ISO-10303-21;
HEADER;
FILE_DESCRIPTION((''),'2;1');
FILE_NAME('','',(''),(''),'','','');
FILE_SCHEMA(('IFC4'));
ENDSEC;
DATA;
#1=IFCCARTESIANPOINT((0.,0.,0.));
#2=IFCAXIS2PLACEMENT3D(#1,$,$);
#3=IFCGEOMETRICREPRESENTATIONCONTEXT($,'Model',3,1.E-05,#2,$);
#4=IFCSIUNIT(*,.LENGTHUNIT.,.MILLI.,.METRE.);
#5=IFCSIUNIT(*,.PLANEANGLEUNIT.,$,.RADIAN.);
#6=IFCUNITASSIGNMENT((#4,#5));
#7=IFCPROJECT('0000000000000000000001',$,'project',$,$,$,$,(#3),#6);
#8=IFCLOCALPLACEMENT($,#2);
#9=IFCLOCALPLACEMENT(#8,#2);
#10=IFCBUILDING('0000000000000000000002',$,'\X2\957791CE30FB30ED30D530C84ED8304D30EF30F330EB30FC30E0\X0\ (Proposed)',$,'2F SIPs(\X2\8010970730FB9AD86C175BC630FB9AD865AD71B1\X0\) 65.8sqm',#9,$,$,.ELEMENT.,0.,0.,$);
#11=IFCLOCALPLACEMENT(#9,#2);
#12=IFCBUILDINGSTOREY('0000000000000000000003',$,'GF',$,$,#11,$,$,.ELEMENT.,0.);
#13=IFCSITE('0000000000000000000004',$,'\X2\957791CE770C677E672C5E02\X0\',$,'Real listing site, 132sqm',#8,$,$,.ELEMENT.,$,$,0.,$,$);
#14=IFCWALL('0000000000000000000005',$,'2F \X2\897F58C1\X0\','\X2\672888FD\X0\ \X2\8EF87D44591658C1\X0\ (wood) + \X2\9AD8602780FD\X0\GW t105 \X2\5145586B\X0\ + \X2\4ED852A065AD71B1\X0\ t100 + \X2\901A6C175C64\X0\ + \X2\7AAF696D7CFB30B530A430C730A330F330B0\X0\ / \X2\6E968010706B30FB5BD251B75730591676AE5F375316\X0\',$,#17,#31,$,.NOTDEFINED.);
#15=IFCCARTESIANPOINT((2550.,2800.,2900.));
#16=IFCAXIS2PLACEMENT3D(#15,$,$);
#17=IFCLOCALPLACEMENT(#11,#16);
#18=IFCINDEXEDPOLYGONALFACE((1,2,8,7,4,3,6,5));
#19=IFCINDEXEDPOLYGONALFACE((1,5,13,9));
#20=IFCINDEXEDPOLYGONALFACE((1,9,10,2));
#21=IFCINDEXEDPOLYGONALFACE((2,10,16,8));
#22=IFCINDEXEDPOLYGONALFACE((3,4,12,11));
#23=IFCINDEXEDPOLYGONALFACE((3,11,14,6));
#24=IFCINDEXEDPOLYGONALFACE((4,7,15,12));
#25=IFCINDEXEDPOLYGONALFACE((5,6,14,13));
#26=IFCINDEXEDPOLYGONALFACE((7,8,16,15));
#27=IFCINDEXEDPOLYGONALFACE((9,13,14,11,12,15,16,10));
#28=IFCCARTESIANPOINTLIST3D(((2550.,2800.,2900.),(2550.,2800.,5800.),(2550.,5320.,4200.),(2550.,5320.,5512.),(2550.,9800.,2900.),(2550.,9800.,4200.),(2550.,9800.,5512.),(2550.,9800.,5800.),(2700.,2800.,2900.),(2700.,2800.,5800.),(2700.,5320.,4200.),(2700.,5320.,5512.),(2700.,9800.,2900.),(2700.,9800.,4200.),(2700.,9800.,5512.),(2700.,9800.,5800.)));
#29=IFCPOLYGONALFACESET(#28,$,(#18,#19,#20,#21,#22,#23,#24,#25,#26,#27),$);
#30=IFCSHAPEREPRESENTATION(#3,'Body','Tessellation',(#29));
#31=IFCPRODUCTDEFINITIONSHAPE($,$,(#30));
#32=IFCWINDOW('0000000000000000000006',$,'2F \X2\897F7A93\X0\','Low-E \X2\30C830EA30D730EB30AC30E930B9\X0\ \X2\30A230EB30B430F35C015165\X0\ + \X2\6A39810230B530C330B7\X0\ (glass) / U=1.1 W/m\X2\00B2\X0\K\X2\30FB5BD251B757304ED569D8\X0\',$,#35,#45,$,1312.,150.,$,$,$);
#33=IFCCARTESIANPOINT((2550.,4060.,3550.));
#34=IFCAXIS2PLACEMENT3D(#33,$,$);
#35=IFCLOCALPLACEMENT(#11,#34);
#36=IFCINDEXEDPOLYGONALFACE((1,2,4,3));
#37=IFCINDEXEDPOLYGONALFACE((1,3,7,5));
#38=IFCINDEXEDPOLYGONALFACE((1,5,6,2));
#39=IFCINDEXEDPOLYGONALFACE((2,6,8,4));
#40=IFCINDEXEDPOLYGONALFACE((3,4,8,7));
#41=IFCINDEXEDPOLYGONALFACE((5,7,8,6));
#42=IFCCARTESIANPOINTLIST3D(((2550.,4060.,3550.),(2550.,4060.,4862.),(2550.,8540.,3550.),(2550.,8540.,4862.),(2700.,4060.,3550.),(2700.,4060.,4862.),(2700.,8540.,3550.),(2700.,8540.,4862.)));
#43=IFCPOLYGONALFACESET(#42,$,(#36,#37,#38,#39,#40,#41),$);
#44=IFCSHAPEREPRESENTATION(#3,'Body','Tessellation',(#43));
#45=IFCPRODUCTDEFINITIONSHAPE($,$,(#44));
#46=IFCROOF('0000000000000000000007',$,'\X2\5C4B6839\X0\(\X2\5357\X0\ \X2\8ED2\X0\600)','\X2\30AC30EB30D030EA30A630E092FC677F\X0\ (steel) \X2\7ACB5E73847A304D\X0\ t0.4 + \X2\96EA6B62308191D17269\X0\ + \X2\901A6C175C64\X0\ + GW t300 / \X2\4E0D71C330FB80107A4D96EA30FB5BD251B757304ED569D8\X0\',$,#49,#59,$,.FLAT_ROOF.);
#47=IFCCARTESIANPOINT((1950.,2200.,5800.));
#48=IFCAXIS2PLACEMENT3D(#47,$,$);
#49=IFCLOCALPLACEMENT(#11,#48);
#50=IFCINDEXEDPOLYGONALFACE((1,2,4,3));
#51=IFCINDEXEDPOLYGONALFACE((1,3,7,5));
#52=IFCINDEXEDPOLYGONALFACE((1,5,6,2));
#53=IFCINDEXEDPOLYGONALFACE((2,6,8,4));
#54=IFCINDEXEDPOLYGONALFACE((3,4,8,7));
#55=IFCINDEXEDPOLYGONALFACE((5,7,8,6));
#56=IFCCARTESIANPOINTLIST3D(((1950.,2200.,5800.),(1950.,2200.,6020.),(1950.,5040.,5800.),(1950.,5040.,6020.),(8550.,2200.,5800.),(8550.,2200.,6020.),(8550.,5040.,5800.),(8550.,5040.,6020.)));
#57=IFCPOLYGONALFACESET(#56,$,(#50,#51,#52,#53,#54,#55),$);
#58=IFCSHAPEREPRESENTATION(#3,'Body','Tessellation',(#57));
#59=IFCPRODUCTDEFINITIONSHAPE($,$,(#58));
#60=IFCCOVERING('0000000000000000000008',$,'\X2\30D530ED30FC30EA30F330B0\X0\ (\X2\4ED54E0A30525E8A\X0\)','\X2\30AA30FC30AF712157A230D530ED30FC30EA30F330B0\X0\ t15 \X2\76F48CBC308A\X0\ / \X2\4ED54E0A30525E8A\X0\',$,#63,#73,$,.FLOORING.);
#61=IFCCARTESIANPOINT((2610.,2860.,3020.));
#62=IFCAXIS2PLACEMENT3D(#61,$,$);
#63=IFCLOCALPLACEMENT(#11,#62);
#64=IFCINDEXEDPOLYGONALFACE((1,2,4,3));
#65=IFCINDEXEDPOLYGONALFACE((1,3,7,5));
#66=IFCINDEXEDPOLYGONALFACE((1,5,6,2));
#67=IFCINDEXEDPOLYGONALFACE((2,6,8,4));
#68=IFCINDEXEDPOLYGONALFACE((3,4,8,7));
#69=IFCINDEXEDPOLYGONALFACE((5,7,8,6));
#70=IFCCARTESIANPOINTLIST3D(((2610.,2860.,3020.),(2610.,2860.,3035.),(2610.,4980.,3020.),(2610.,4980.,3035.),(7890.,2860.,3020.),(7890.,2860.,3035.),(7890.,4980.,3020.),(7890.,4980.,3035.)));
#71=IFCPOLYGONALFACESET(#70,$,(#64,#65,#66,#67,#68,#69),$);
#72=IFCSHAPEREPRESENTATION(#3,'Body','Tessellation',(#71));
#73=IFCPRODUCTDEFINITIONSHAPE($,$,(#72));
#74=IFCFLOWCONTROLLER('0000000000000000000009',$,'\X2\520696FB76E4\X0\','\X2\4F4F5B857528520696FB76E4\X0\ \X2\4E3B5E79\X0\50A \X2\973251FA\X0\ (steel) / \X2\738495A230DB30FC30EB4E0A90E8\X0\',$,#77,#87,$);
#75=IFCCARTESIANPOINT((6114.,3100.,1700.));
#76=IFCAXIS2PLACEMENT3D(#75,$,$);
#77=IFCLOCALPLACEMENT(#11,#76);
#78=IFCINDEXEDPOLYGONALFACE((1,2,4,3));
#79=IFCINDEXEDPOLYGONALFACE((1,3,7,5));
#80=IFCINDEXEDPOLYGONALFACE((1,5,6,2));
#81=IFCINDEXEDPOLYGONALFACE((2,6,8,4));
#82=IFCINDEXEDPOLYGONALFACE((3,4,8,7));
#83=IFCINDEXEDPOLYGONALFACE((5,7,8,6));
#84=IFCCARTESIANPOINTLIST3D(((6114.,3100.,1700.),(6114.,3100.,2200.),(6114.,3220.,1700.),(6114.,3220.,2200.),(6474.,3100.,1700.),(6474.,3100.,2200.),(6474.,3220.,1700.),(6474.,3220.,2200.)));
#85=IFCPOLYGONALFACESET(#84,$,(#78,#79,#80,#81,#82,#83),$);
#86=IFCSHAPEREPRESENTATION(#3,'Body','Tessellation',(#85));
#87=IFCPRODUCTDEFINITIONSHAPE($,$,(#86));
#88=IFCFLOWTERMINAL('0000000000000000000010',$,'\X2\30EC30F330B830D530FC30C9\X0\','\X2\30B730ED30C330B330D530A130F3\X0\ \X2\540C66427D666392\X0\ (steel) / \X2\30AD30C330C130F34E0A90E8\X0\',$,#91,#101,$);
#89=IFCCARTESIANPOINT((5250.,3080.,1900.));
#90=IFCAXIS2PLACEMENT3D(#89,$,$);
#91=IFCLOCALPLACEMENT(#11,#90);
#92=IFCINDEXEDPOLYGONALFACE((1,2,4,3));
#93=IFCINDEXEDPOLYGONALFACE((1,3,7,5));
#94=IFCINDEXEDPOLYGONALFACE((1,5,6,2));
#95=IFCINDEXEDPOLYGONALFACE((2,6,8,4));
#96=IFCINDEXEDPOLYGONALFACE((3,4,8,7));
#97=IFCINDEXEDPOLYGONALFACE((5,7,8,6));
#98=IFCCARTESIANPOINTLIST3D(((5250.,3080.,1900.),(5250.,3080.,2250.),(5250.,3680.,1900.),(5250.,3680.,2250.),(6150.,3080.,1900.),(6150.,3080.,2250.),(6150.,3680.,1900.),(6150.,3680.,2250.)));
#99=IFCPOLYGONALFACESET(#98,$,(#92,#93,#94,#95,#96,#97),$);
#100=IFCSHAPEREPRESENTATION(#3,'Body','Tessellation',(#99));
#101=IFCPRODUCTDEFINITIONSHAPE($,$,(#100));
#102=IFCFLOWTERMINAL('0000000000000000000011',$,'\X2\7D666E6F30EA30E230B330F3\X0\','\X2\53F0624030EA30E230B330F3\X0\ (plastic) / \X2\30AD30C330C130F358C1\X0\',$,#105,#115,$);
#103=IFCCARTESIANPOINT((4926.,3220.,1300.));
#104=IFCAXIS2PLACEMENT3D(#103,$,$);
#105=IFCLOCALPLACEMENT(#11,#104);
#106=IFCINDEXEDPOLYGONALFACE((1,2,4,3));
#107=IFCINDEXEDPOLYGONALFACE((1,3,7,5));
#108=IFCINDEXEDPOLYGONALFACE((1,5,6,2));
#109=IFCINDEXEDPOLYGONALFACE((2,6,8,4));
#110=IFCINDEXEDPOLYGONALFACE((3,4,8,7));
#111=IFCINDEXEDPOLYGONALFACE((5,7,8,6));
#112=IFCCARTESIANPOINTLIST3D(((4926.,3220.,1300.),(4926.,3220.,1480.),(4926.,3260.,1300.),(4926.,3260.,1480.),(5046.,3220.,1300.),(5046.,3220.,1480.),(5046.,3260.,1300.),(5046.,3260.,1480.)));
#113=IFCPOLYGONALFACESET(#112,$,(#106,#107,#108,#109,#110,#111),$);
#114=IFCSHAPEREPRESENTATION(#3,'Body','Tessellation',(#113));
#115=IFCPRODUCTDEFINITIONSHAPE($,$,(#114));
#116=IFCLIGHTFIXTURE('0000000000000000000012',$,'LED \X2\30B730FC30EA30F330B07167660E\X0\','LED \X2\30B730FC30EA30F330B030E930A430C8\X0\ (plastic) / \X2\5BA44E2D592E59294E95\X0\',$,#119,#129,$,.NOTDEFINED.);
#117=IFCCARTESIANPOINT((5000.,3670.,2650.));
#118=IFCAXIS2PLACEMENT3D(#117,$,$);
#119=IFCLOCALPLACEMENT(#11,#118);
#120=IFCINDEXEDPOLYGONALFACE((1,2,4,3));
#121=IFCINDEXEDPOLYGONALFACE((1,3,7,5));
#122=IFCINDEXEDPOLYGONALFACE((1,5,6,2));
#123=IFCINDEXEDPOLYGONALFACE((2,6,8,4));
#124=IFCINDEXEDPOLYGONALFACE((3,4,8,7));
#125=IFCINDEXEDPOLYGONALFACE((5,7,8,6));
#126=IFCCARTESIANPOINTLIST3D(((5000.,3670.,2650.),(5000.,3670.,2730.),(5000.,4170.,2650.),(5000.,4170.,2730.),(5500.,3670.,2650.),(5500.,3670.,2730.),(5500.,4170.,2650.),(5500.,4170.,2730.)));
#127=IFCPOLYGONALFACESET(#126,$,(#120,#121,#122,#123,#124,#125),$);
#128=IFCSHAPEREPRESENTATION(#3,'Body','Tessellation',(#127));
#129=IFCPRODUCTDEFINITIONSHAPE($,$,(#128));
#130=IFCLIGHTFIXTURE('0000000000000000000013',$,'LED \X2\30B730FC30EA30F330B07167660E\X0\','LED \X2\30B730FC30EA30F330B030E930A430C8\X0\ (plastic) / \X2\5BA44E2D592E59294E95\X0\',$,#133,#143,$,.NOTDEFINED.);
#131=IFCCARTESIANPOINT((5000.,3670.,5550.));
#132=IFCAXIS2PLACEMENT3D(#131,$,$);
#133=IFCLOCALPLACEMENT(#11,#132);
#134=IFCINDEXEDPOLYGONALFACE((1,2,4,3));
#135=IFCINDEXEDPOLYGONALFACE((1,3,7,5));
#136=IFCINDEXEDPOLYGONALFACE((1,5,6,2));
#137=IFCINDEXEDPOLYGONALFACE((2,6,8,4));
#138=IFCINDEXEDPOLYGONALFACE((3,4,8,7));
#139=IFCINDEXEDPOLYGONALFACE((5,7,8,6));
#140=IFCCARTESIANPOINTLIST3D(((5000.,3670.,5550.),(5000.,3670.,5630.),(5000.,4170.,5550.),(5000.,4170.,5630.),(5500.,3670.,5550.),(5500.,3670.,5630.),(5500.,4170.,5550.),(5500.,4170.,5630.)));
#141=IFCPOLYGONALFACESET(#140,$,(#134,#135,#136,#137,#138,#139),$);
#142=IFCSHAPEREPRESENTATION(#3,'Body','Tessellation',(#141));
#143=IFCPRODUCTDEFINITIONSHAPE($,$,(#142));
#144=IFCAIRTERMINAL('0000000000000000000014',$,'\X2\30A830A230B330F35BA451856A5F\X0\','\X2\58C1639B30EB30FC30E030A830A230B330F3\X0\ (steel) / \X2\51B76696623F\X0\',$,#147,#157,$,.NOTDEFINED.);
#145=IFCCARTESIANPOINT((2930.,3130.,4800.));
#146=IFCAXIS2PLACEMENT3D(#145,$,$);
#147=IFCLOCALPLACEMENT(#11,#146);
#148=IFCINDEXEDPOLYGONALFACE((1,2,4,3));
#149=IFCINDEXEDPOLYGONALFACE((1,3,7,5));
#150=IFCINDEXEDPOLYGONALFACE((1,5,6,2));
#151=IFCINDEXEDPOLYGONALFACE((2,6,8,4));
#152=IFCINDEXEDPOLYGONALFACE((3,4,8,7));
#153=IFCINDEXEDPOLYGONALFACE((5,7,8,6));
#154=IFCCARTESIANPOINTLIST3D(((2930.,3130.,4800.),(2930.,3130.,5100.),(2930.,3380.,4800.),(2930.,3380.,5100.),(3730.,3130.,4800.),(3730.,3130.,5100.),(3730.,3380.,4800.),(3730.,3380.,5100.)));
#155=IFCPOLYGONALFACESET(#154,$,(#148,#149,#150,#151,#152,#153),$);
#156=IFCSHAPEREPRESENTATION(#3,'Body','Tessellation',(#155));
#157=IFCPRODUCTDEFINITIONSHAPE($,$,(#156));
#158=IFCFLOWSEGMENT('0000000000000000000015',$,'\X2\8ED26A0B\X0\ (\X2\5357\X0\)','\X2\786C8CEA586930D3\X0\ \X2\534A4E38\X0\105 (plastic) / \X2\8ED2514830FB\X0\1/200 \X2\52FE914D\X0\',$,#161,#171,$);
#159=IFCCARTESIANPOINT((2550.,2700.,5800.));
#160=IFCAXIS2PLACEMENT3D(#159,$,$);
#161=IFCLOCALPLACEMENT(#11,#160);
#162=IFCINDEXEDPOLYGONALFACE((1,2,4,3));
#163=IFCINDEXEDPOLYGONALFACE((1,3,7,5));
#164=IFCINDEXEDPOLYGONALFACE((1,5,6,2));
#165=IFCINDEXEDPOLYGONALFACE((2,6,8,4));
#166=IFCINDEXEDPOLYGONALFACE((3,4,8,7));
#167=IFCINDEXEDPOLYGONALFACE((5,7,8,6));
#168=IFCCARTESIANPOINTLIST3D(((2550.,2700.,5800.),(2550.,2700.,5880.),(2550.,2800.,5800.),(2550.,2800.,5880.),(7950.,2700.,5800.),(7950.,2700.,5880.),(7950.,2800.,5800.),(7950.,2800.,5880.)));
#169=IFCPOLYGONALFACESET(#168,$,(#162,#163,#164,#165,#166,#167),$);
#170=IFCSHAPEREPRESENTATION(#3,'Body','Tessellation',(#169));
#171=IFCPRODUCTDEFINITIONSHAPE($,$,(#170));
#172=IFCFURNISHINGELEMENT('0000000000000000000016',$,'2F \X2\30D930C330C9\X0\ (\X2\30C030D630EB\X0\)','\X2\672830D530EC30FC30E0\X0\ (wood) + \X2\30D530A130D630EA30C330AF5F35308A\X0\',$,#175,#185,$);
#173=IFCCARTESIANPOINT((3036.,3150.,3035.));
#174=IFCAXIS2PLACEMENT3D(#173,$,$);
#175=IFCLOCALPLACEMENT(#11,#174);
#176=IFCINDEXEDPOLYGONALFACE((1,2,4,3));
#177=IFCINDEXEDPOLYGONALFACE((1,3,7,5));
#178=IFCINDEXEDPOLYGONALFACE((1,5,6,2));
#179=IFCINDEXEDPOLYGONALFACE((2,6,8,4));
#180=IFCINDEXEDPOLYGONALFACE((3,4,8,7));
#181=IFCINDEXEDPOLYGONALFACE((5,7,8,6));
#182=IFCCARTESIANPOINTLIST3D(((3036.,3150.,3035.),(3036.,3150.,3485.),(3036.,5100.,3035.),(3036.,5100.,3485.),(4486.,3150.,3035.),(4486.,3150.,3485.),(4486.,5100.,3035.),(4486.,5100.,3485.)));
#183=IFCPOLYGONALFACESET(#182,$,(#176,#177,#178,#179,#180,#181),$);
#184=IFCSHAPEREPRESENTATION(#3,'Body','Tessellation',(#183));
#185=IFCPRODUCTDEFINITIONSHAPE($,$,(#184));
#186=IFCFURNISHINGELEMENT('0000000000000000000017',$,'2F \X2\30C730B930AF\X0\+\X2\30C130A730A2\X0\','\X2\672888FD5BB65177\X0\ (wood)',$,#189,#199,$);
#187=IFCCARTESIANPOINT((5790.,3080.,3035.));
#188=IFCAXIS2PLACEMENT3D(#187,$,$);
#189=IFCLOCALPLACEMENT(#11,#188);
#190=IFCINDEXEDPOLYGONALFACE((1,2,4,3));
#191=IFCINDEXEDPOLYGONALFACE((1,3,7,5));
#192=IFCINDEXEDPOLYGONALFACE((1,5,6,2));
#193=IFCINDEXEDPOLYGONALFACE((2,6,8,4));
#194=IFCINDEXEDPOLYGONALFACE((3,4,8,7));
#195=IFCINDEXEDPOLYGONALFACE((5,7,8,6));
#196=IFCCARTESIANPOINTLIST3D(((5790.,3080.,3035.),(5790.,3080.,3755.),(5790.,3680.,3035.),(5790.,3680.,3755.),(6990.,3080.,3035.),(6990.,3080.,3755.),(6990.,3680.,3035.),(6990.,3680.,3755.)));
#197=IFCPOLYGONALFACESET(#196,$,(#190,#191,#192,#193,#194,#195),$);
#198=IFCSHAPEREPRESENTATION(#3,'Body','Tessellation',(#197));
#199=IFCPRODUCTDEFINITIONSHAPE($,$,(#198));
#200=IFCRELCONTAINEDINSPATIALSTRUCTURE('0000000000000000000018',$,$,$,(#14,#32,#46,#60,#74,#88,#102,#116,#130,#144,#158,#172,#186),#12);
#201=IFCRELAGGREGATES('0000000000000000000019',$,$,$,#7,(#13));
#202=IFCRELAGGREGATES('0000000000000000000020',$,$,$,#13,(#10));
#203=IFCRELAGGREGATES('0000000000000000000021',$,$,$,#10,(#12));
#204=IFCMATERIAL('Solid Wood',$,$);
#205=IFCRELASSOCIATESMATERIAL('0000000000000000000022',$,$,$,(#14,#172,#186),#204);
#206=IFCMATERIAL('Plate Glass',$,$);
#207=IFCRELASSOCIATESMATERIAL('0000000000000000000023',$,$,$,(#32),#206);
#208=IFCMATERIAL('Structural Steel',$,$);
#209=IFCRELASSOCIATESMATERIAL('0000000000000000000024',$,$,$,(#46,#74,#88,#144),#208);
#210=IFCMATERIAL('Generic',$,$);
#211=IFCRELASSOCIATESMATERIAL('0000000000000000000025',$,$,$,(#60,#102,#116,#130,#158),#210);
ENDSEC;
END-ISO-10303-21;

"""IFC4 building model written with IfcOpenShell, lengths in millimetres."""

from ifc_helpers import new_model, si_unit, frame, frame_2d, origin, place, context, project, spatial, rectangle, extrude, material, element, fill, save


model = new_model("IFC4")

# Units and contexts
model_context = context("Model", 3, precision=1e-05, world=origin())
ifc_project = project(units=[si_unit("LENGTHUNIT", "METRE", prefix="MILLI"), si_unit("PLANEANGLEUNIT", "RADIAN")], contexts=[model_context])

# Site, building, storey
site_placement = place(None, origin())
site = spatial("IfcSite", under=ifc_project, at=site_placement, Name="長野県松本市", ObjectType="Real listing site, 132sqm", CompositionType="ELEMENT", RefElevation=0.0)
building_placement = place(site_placement, origin())
building = spatial("IfcBuilding", under=site, at=building_placement, Name="長野・ロフト付きワンルーム (Proposed)", ObjectType="2F SIPs(耐震・高気密・高断熱) 65.8sqm", CompositionType="ELEMENT", ElevationOfRefHeight=0.0, ElevationOfTerrain=0.0)
storey_placement = place(building_placement, origin())
storey = spatial("IfcBuildingStorey", under=building, at=storey_placement, Name="GF", CompositionType="ELEMENT", Elevation=0.0)

# Shared definitions
ifc_material_1 = material(Name="Solid Wood")

# Wall, opening, window
ifc_material_2 = material(Name="Plate Glass")
wall_1_placement = place(storey_placement, frame((2550.0, 2800.0, 2900.0)))
wall_1 = element("IfcWall", 1, at=wall_1_placement, inside=storey, material=ifc_material_1, Name="2F 西壁", Description="木製 軸組外壁 (wood) + 高性能GW t105 充填 + 付加断熱 t100 + 通気層 + 窯業系サイディング / 準耐火・寒冷地外皮強化", PredefinedType="NOTDEFINED", context=model_context, shape_type="SweptSolid", body=[
    extrude(rectangle(XDim=150.0, YDim=7000.0, at=frame_2d((75.0, 3500.0))), frame((2550.0, 2800.0, 2900.0)), (0.0, 0.0, 1.0), 2900.0),
])
opening_1_placement = place(storey_placement, frame((2550.0, 4060.0, 3550.0)))
opening_1 = element("IfcOpeningElement", 2, at=opening_1_placement, cuts=wall_1, PredefinedType="NOTDEFINED", context=model_context, shape_type="SweptSolid", body=[
    extrude(rectangle(XDim=150.0, YDim=4480.0, at=frame_2d((75.0, 2240.0))), frame((2550.0, 4060.0, 3550.0)), (0.0, 0.0, 1.0), 1312.0),
])
window_1_placement = place(storey_placement, frame((2550.0, 4060.0, 3550.0)))
window_1 = element("IfcWindow", 3, at=window_1_placement, inside=storey, material=ifc_material_2, Name="2F 西窓", Description="Low-E トリプルガラス アルゴン封入 + 樹脂サッシ (glass) / U=1.1 W/m²K・寒冷地仕様", OverallHeight=1312.0, OverallWidth=150.0, context=model_context, shape_type="SweptSolid", body=[
    extrude(rectangle(XDim=150.0, YDim=4480.0, at=frame_2d((75.0, 2240.0))), frame((2550.0, 4060.0, 3550.0)), (0.0, 0.0, 1.0), 1312.0),
])
fill(opening_1, window_1)

# Roof
ifc_material_3 = material(Name="Structural Steel")
for number, where, name in (
    (4, (1950.0, 2200.0, 5800.0), "屋根(南 軒600)"),
):
    element("IfcRoof", number, at=place(storey_placement, frame(where)), inside=storey, material=ifc_material_3, Name=name, Description="ガルバリウム鋼板 (steel) 立平葺き t0.4 + 雪止め金物 + 通気層 + GW t300 / 不燃・耐積雪・寒冷地仕様", PredefinedType="FLAT_ROOF", context=model_context, shape_type="SweptSolid", body=[
        extrude(rectangle(XDim=6600.0, YDim=2840.0, at=frame_2d((3300.0, 1420.0))), frame((1950.0, 2200.0, 5800.0)), (0.0, 0.0, 1.0), 220.0),
    ])

# Covering
ifc_material_4 = material(Name="Generic")
covering_placement = place(storey_placement, frame((2610.0, 2860.0, 3020.0)))
element("IfcCovering", 5, at=covering_placement, inside=storey, material=ifc_material_4, Name="フローリング (仕上げ床)", Description="オーク無垢フローリング t15 直貼り / 仕上げ床", PredefinedType="FLOORING", context=model_context, shape_type="SweptSolid", body=[
    extrude(rectangle(XDim=5280.0, YDim=2120.0, at=frame_2d((2640.0, 1060.0))), frame((2610.0, 2860.0, 3020.0)), (0.0, 0.0, 1.0), 15.0),
])

# Flow controller
flow_controller_placement = place(storey_placement, frame((6114.0, 3100.0, 1700.0)))
element("IfcFlowController", 6, at=flow_controller_placement, inside=storey, material=ifc_material_3, Name="分電盤", Description="住宅用分電盤 主幹50A 露出 (steel) / 玄関ホール上部", context=model_context, shape_type="SweptSolid", body=[
    extrude(rectangle(XDim=360.0, YDim=120.0, at=frame_2d((180.0, 60.0))), frame((6114.0, 3100.0, 1700.0)), (0.0, 0.0, 1.0), 500.0),
])

# Flow terminals
flow_terminal_1_placement = place(storey_placement, frame((5250.0, 3080.0, 1900.0)))
element("IfcFlowTerminal", 7, at=flow_terminal_1_placement, inside=storey, material=ifc_material_3, Name="レンジフード", Description="シロッコファン 同時給排 (steel) / キッチン上部", context=model_context, shape_type="SweptSolid", body=[
    extrude(rectangle(XDim=900.0, YDim=600.0, at=frame_2d((450.0, 300.0))), frame((5250.0, 3080.0, 1900.0)), (0.0, 0.0, 1.0), 350.0),
])
flow_terminal_2_placement = place(storey_placement, frame((4926.0, 3220.0, 1300.0)))
element("IfcFlowTerminal", 8, at=flow_terminal_2_placement, inside=storey, material=ifc_material_4, Name="給湯リモコン", Description="台所リモコン (plastic) / キッチン壁", context=model_context, shape_type="SweptSolid", body=[
    extrude(rectangle(XDim=120.0, YDim=40.0, at=frame_2d((60.0, 20.0))), frame((4926.0, 3220.0, 1300.0)), (0.0, 0.0, 1.0), 180.0),
])

# Light fixtures
light_fixture_1_placement = place(storey_placement, frame((5000.0, 3670.0, 2650.0)))
element("IfcLightFixture", 9, at=light_fixture_1_placement, inside=storey, material=ifc_material_4, Name="LED シーリング照明", Description="LED シーリングライト (plastic) / 室中央天井", PredefinedType="NOTDEFINED", context=model_context, shape_type="SweptSolid", body=[
    extrude(rectangle(XDim=500.0, YDim=500.0, at=frame_2d((250.0, 250.0))), frame((5000.0, 3670.0, 2650.0)), (0.0, 0.0, 1.0), 80.0),
])
light_fixture_2_placement = place(storey_placement, frame((5000.0, 3670.0, 5550.0)))
element("IfcLightFixture", 10, at=light_fixture_2_placement, inside=storey, material=ifc_material_4, Name="LED シーリング照明", Description="LED シーリングライト (plastic) / 室中央天井", PredefinedType="NOTDEFINED", context=model_context, shape_type="SweptSolid", body=[
    extrude(rectangle(XDim=500.0, YDim=500.0, at=frame_2d((250.0, 250.0))), frame((5000.0, 3670.0, 5550.0)), (0.0, 0.0, 1.0), 80.0),
])

# Air terminal
air_terminal_placement = place(storey_placement, frame((2930.0, 3130.0, 4800.0)))
element("IfcAirTerminal", 11, at=air_terminal_placement, inside=storey, material=ifc_material_3, Name="エアコン室内機", Description="壁掛ルームエアコン (steel) / 冷暖房", PredefinedType="NOTDEFINED", context=model_context, shape_type="SweptSolid", body=[
    extrude(rectangle(XDim=800.0, YDim=250.0, at=frame_2d((400.0, 125.0))), frame((2930.0, 3130.0, 4800.0)), (0.0, 0.0, 1.0), 300.0),
])

# Flow segment
flow_segment_placement = place(storey_placement, frame((2550.0, 2700.0, 5800.0)))
element("IfcFlowSegment", 12, at=flow_segment_placement, inside=storey, material=ifc_material_4, Name="軒樋 (南)", Description="硬質塩ビ 半丸105 (plastic) / 軒先・1/200 勾配", context=model_context, shape_type="SweptSolid", body=[
    extrude(rectangle(XDim=5400.0, YDim=100.0, at=frame_2d((2700.0, 50.0))), frame((2550.0, 2700.0, 5800.0)), (0.0, 0.0, 1.0), 80.0),
])

# Furnishing elements
furnishing_1_placement = place(storey_placement, frame((3036.0, 3150.0, 3035.0)))
element("IfcFurnishingElement", 13, at=furnishing_1_placement, inside=storey, material=ifc_material_1, Name="2F ベッド (ダブル)", Description="木フレーム (wood) + ファブリック張り", context=model_context, shape_type="SweptSolid", body=[
    extrude(rectangle(XDim=1450.0, YDim=1950.0, at=frame_2d((725.0, 975.0))), frame((3036.0, 3150.0, 3035.0)), (0.0, 0.0, 1.0), 450.0),
])
furnishing_2_placement = place(storey_placement, frame((5790.0, 3080.0, 3035.0)))
element("IfcFurnishingElement", 14, at=furnishing_2_placement, inside=storey, material=ifc_material_1, Name="2F デスク+チェア", Description="木製家具 (wood)", context=model_context, shape_type="SweptSolid", body=[
    extrude(rectangle(XDim=1200.0, YDim=600.0, at=frame_2d((600.0, 300.0))), frame((5790.0, 3080.0, 3035.0)), (0.0, 0.0, 1.0), 720.0),
])

save(model, "model.ifc")
